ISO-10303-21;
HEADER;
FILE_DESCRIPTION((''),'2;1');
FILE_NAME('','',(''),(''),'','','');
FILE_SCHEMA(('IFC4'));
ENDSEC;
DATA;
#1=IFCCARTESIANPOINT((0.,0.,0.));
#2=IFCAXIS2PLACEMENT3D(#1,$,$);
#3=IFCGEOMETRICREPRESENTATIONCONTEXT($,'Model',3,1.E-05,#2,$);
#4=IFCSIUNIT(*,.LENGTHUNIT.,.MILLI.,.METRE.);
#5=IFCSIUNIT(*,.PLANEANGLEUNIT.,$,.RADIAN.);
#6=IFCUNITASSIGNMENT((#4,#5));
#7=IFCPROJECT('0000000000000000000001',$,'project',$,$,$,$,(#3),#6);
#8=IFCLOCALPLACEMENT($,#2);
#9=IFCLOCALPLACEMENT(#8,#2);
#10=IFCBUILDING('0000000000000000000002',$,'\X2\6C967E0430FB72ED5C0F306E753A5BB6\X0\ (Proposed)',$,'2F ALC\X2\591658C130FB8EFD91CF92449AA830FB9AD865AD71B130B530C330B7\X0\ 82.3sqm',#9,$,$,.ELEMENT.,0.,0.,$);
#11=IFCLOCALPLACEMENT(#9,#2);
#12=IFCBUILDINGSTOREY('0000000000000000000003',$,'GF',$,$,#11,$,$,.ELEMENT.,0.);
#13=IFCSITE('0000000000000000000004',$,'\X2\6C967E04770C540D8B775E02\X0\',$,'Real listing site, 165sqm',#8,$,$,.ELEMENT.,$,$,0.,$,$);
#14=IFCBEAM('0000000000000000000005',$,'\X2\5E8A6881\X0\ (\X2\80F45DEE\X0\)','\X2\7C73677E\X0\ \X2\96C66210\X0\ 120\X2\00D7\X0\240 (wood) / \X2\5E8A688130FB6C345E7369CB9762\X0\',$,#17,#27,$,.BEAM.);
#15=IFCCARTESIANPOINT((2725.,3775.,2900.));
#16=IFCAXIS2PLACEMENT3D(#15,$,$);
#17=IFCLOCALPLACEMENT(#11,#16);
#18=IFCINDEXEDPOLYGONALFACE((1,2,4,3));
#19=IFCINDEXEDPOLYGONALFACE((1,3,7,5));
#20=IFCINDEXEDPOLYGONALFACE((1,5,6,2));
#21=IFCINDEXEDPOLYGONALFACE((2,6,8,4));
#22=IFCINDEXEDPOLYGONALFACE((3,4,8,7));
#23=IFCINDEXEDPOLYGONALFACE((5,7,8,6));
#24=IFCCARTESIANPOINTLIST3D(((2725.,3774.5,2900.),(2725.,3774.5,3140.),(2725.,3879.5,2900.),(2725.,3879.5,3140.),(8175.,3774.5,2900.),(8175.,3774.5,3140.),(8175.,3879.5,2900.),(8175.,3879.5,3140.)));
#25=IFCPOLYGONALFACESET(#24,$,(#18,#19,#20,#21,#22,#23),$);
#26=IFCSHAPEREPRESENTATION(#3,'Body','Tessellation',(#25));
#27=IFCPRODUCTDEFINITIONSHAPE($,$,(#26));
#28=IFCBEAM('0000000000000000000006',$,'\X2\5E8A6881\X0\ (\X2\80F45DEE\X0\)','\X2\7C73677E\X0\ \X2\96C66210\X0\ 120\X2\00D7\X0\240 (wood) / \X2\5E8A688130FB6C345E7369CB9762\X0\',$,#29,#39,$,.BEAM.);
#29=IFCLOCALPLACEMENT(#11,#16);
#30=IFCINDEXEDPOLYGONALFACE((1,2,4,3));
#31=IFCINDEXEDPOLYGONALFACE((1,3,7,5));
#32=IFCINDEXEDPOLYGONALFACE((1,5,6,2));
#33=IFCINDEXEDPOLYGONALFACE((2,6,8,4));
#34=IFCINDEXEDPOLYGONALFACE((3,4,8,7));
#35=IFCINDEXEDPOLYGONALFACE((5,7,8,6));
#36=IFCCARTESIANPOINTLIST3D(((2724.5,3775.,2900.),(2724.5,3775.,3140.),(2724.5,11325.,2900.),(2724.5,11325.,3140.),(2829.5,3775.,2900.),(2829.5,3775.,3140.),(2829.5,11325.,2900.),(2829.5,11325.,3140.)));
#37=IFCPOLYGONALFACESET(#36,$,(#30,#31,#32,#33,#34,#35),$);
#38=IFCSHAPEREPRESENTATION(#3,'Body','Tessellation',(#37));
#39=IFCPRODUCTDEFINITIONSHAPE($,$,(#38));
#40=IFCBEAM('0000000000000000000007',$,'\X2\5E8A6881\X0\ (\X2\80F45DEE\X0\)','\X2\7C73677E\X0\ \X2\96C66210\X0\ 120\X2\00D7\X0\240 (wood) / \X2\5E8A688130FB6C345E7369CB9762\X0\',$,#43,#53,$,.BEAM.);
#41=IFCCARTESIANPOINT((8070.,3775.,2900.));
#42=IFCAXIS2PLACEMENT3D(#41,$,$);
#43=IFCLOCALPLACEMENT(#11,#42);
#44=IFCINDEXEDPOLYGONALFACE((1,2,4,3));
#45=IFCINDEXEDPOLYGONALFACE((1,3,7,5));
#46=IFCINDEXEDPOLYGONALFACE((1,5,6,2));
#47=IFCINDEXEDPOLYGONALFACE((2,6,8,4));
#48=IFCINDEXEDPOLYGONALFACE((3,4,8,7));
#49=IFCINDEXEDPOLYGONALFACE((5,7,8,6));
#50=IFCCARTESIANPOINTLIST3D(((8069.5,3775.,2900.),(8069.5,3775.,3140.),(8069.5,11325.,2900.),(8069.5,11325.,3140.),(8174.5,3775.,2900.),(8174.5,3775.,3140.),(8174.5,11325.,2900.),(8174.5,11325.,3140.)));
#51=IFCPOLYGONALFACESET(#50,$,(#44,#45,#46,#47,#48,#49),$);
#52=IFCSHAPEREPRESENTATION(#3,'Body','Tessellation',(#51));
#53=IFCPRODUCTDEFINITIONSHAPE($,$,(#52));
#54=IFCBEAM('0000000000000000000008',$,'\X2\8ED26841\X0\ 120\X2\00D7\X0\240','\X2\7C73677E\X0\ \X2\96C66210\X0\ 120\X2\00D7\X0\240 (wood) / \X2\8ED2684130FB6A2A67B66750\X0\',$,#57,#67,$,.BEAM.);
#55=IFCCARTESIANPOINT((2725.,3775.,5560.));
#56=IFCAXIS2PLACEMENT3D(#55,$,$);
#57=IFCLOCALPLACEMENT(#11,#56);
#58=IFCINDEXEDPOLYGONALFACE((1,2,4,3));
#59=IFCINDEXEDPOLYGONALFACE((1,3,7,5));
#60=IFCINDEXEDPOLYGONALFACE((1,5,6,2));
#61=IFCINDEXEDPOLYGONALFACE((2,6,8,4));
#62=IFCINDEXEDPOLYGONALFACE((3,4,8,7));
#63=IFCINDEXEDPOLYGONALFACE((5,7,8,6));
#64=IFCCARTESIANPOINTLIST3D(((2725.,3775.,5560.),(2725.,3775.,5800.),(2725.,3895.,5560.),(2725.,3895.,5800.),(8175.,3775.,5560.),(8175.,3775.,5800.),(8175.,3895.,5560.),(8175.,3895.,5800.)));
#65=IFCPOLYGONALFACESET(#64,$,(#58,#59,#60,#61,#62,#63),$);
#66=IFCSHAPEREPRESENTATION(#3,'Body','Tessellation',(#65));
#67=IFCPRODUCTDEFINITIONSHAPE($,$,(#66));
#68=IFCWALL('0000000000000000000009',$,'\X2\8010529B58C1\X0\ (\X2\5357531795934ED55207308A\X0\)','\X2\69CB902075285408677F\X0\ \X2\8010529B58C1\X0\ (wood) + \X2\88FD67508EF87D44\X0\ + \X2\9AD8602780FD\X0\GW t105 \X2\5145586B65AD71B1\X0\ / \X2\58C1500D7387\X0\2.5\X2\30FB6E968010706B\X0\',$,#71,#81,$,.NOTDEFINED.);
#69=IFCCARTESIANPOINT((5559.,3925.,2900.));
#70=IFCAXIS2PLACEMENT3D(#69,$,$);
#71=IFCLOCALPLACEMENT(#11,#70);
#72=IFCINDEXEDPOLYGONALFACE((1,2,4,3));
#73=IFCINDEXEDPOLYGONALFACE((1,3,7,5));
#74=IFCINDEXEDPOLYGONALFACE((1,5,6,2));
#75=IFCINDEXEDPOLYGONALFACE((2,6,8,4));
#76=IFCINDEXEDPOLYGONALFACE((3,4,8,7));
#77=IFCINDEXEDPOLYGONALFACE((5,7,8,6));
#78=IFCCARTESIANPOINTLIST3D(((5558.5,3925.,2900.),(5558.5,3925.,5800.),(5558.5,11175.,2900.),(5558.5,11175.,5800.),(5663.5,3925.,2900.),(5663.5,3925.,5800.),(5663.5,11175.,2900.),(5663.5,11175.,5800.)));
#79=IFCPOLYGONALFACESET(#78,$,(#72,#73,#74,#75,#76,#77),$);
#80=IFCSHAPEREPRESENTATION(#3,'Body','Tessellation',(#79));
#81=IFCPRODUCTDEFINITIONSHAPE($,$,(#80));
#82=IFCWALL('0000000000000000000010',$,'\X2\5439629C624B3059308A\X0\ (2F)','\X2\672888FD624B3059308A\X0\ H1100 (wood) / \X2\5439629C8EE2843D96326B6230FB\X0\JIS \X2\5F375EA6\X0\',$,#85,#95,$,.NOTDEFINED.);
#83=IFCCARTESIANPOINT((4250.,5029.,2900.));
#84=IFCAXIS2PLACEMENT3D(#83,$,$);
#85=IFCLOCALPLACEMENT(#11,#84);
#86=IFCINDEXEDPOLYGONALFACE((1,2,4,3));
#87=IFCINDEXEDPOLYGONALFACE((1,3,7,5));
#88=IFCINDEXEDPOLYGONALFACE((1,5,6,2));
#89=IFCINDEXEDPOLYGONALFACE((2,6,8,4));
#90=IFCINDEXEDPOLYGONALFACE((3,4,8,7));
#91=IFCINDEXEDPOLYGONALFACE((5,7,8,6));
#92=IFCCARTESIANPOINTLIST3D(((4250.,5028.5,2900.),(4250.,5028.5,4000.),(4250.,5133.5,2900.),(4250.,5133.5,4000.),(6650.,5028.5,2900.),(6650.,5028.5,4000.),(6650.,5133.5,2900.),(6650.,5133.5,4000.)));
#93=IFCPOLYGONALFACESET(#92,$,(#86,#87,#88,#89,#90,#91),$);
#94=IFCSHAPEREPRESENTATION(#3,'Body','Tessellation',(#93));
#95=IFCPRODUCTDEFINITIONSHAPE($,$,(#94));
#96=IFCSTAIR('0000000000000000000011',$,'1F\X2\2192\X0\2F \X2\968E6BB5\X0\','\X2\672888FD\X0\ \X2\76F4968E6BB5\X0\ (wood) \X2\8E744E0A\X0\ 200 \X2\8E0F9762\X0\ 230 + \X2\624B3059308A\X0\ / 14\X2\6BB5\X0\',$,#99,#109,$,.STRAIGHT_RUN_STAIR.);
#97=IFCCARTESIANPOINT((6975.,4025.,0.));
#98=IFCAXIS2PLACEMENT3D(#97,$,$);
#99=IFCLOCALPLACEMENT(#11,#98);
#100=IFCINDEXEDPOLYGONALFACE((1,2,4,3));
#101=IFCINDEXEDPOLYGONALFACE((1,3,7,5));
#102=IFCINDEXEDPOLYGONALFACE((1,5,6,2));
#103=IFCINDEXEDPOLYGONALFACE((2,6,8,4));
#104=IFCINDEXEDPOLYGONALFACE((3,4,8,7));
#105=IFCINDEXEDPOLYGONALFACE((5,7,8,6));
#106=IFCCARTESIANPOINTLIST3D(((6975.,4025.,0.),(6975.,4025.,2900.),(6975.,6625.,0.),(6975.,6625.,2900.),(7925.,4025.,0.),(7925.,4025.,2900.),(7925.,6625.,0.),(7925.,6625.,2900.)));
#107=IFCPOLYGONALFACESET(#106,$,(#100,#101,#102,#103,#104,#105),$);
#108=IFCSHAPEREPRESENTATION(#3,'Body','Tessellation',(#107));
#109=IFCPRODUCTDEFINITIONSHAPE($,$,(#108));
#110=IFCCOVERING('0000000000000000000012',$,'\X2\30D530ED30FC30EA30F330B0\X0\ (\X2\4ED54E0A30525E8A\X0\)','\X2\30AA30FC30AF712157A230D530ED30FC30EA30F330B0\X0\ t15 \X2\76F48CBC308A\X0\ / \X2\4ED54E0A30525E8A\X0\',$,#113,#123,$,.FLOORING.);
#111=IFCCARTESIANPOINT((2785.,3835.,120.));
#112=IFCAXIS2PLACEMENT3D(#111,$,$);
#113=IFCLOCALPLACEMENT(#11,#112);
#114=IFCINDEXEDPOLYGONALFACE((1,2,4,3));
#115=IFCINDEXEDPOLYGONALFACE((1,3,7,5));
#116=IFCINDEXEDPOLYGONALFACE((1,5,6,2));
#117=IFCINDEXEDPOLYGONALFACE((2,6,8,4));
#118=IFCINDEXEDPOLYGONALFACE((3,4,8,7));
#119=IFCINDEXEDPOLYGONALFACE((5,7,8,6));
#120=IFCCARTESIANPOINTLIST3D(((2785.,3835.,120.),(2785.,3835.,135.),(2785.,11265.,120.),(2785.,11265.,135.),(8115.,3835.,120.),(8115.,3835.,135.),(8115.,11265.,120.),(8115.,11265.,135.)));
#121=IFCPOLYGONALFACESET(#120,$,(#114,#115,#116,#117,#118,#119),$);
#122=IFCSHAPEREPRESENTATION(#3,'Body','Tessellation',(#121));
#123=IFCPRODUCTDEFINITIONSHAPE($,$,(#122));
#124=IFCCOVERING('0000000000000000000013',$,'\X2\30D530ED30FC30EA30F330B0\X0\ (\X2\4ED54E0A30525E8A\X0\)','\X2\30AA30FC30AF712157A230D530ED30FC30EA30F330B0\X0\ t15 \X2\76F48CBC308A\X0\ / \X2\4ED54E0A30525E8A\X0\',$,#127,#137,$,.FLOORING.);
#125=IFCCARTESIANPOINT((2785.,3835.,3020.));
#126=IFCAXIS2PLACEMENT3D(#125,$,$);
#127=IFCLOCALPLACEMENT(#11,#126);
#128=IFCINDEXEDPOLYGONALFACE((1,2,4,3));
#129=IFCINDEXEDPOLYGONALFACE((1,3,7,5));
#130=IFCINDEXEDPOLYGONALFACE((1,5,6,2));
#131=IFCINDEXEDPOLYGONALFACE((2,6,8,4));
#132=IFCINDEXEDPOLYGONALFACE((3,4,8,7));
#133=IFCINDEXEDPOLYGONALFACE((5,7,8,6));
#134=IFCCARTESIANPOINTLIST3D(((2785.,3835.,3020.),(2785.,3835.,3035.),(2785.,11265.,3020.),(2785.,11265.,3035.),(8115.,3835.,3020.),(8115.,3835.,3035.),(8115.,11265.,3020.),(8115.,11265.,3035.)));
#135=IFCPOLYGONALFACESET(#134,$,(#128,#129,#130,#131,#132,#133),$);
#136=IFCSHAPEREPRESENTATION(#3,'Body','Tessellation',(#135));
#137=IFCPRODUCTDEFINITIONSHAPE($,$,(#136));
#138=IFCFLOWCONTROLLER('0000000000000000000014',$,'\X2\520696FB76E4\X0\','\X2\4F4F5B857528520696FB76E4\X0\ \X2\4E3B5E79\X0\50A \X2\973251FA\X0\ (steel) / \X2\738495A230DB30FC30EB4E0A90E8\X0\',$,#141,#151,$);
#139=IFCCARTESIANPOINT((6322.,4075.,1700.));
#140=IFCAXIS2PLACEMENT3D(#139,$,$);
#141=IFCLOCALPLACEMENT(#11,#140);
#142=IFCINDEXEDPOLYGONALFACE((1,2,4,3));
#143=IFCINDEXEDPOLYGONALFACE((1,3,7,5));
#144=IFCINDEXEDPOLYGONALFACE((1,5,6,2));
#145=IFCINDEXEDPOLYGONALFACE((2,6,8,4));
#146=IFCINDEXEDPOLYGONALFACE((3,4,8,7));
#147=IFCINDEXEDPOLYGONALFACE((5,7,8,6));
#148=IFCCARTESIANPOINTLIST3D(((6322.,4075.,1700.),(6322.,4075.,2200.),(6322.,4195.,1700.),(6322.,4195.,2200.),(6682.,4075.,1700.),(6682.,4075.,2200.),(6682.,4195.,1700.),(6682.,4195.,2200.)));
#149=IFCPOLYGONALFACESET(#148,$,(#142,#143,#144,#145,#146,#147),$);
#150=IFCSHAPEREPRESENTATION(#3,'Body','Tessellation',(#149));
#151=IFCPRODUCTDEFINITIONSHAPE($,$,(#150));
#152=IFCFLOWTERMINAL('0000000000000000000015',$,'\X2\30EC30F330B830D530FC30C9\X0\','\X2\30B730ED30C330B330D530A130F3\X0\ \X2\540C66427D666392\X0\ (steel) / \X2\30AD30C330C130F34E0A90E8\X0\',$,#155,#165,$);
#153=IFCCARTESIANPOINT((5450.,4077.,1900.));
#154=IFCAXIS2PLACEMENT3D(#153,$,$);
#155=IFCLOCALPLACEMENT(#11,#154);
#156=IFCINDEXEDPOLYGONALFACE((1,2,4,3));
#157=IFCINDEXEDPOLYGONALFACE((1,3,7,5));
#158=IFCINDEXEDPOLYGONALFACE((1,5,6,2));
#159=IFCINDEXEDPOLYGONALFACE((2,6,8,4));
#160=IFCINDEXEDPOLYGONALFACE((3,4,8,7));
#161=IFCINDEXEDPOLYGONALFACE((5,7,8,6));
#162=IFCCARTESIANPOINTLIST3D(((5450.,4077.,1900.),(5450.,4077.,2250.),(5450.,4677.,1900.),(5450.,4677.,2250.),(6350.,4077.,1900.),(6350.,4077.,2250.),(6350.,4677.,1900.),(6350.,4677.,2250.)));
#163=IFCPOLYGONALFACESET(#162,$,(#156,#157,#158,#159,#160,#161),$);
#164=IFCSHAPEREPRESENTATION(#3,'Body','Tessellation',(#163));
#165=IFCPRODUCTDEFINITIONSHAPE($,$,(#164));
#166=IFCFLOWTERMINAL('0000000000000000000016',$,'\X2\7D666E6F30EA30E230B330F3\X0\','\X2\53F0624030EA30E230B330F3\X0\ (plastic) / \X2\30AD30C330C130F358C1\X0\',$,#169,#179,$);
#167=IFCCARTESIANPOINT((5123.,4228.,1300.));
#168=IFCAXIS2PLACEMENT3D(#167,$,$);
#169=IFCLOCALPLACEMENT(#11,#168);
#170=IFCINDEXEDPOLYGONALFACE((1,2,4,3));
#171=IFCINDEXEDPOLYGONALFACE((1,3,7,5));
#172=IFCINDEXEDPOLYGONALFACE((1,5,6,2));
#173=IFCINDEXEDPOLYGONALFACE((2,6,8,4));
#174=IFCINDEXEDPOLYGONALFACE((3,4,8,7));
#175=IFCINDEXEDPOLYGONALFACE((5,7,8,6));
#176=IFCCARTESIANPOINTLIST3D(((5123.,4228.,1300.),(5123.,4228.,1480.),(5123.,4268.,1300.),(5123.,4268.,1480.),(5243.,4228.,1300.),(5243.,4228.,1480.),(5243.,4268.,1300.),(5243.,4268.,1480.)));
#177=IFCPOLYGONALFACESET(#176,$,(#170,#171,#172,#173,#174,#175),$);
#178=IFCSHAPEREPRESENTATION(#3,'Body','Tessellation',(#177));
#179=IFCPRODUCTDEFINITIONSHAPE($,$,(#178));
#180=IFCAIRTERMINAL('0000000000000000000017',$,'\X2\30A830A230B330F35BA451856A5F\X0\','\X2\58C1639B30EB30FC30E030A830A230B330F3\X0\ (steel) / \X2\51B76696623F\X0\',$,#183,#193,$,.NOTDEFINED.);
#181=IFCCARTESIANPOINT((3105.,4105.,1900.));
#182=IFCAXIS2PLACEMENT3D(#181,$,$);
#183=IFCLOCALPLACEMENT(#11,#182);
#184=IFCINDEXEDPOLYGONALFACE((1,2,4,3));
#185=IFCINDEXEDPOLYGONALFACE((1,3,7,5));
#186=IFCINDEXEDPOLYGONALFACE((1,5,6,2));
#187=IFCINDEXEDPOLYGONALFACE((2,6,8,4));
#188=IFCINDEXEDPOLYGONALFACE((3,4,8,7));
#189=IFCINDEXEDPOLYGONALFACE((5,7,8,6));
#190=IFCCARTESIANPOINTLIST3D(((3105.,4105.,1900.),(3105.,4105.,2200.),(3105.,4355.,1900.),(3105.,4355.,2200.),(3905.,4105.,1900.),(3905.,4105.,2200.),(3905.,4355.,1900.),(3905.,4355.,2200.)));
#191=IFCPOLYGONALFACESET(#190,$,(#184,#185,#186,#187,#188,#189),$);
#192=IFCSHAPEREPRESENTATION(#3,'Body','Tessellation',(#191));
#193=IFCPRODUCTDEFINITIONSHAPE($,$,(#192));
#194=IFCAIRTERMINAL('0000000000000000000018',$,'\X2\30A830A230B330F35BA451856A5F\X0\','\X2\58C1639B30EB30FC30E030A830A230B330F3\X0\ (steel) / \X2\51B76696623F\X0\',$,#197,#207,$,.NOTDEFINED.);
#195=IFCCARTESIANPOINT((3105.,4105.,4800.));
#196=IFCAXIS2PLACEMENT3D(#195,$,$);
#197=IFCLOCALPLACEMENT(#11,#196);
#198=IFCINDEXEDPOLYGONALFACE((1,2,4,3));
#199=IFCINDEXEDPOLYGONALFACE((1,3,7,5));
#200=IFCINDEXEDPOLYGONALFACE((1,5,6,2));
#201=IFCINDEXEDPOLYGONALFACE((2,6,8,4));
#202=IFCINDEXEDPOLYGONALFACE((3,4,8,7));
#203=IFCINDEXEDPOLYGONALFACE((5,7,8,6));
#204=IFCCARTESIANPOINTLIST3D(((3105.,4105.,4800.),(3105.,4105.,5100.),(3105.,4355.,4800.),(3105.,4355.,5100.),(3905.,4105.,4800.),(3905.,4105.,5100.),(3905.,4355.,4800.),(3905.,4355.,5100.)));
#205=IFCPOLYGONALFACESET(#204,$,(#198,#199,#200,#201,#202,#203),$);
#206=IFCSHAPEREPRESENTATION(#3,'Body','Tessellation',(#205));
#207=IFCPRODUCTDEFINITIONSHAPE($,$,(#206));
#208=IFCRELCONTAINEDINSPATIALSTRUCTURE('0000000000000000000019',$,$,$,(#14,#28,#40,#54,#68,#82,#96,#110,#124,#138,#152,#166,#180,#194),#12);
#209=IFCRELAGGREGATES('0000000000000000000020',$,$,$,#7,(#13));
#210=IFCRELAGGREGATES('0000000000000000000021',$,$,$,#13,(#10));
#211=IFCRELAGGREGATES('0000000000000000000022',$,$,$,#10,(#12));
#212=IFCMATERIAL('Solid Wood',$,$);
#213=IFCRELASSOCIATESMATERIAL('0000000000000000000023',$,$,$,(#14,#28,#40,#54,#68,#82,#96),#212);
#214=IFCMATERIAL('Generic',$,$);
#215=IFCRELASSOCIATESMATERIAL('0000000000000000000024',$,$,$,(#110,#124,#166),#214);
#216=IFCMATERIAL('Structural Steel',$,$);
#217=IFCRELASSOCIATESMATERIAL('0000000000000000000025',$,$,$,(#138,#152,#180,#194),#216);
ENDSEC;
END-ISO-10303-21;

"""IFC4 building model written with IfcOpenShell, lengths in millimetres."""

from ifc_helpers import new_model, si_unit, frame, frame_2d, origin, place, context, project, spatial, rectangle, extrude, material, element, save


model = new_model("IFC4")

# Units and contexts
model_context = context("Model", 3, precision=1e-05, world=origin())
ifc_project = project(units=[si_unit("LENGTHUNIT", "METRE", prefix="MILLI"), si_unit("PLANEANGLEUNIT", "RADIAN")], contexts=[model_context])

# Site, building, storey
site_placement = place(None, origin())
site = spatial("IfcSite", under=ifc_project, at=site_placement, Name="沖縄県名護市", ObjectType="Real listing site, 165sqm", CompositionType="ELEMENT", RefElevation=0.0)
building_placement = place(site_placement, origin())
building = spatial("IfcBuilding", under=site, at=building_placement, Name="沖縄・狭小の町家 (Proposed)", ObjectType="2F ALC外壁・軽量鉄骨・高断熱サッシ 82.3sqm", CompositionType="ELEMENT", ElevationOfRefHeight=0.0, ElevationOfTerrain=0.0)
storey_placement = place(building_placement, origin())
storey = spatial("IfcBuildingStorey", under=building, at=storey_placement, Name="GF", CompositionType="ELEMENT", Elevation=0.0)

# Shared definitions
ifc_material_1 = material(Name="Solid Wood")

# Beams
beam_1_placement = place(storey_placement, frame((2725.0, 3775.0, 2900.0)))
element("IfcBeam", 1, at=beam_1_placement, inside=storey, material=ifc_material_1, Name="床梁 (胴差)", Description="米松 集成 120×240 (wood) / 床梁・水平構面", PredefinedType="BEAM", context=model_context, shape_type="SweptSolid", body=[
    extrude(rectangle(XDim=5450.0, YDim=105.0, at=frame_2d((2725.0, 52.0))), frame((2725.0, 3775.0, 2900.0)), (0.0, 0.0, 1.0), 240.0),
])
beam_2_placement = place(storey_placement, frame((2725.0, 3775.0, 2900.0)))
element("IfcBeam", 2, at=beam_2_placement, inside=storey, material=ifc_material_1, Name="床梁 (胴差)", Description="米松 集成 120×240 (wood) / 床梁・水平構面", PredefinedType="BEAM", context=model_context, shape_type="SweptSolid", body=[
    extrude(rectangle(XDim=105.0, YDim=7550.0, at=frame_2d((52.0, 3775.0))), frame((2725.0, 3775.0, 2900.0)), (0.0, 0.0, 1.0), 240.0),
])
beam_3_placement = place(storey_placement, frame((8070.0, 3775.0, 2900.0)))
element("IfcBeam", 3, at=beam_3_placement, inside=storey, material=ifc_material_1, Name="床梁 (胴差)", Description="米松 集成 120×240 (wood) / 床梁・水平構面", PredefinedType="BEAM", context=model_context, shape_type="SweptSolid", body=[
    extrude(rectangle(XDim=105.0, YDim=7550.0, at=frame_2d((52.0, 3775.0))), frame((8070.0, 3775.0, 2900.0)), (0.0, 0.0, 1.0), 240.0),
])
beam_4_placement = place(storey_placement, frame((2725.0, 3775.0, 5560.0)))
element("IfcBeam", 4, at=beam_4_placement, inside=storey, material=ifc_material_1, Name="軒桁 120×240", Description="米松 集成 120×240 (wood) / 軒桁・横架材", PredefinedType="BEAM", context=model_context, shape_type="SweptSolid", body=[
    extrude(rectangle(XDim=5450.0, YDim=120.0, at=frame_2d((2725.0, 60.0))), frame((2725.0, 3775.0, 5560.0)), (0.0, 0.0, 1.0), 240.0),
])

# Walls
wall_1_placement = place(storey_placement, frame((5559.0, 3925.0, 2900.0)))
element("IfcWall", 5, at=wall_1_placement, inside=storey, material=ifc_material_1, Name="耐力壁 (南北間仕切り)", Description="構造用合板 耐力壁 (wood) + 製材軸組 + 高性能GW t105 充填断熱 / 壁倍率2.5・準耐火", PredefinedType="NOTDEFINED", context=model_context, shape_type="SweptSolid", body=[
    extrude(rectangle(XDim=105.0, YDim=7250.0, at=frame_2d((52.0, 3625.0))), frame((5559.0, 3925.0, 2900.0)), (0.0, 0.0, 1.0), 2900.0),
])
wall_2_placement = place(storey_placement, frame((4250.0, 5029.0, 2900.0)))
element("IfcWall", 6, at=wall_2_placement, inside=storey, material=ifc_material_1, Name="吹抜手すり (2F)", Description="木製手すり H1100 (wood) / 吹抜転落防止・JIS 強度", PredefinedType="NOTDEFINED", context=model_context, shape_type="SweptSolid", body=[
    extrude(rectangle(XDim=2400.0, YDim=105.0, at=frame_2d((1200.0, 52.0))), frame((4250.0, 5029.0, 2900.0)), (0.0, 0.0, 1.0), 1100.0),
])

# Stair
stair_placement = place(storey_placement, frame((6975.0, 4025.0, 0.0)))
element("IfcStair", 7, at=stair_placement, inside=storey, material=ifc_material_1, Name="1F→2F 階段", Description="木製 直階段 (wood) 蹴上 200 踏面 230 + 手すり / 14段", PredefinedType="STRAIGHT_RUN_STAIR", context=model_context, shape_type="SweptSolid", body=[
    extrude(rectangle(XDim=950.0, YDim=2600.0, at=frame_2d((475.0, 1300.0))), frame((6975.0, 4025.0, 0.0)), (0.0, 0.0, 1.0), 2900.0),
])

# Coverings
ifc_material_2 = material(Name="Generic")
covering_1_placement = place(storey_placement, frame((2785.0, 3835.0, 120.0)))
element("IfcCovering", 8, at=covering_1_placement, inside=storey, material=ifc_material_2, Name="フローリング (仕上げ床)", Description="オーク無垢フローリング t15 直貼り / 仕上げ床", PredefinedType="FLOORING", context=model_context, shape_type="SweptSolid", body=[
    extrude(rectangle(XDim=5330.0, YDim=7430.0, at=frame_2d((2665.0, 3715.0))), frame((2785.0, 3835.0, 120.0)), (0.0, 0.0, 1.0), 15.0),
])
covering_2_placement = place(storey_placement, frame((2785.0, 3835.0, 3020.0)))
element("IfcCovering", 9, at=covering_2_placement, inside=storey, material=ifc_material_2, Name="フローリング (仕上げ床)", Description="オーク無垢フローリング t15 直貼り / 仕上げ床", PredefinedType="FLOORING", context=model_context, shape_type="SweptSolid", body=[
    extrude(rectangle(XDim=5330.0, YDim=7430.0, at=frame_2d((2665.0, 3715.0))), frame((2785.0, 3835.0, 3020.0)), (0.0, 0.0, 1.0), 15.0),
])

# Flow controller
ifc_material_3 = material(Name="Structural Steel")
flow_controller_placement = place(storey_placement, frame((6322.0, 4075.0, 1700.0)))
element("IfcFlowController", 10, at=flow_controller_placement, inside=storey, material=ifc_material_3, Name="分電盤", Description="住宅用分電盤 主幹50A 露出 (steel) / 玄関ホール上部", context=model_context, shape_type="SweptSolid", body=[
    extrude(rectangle(XDim=360.0, YDim=120.0, at=frame_2d((180.0, 60.0))), frame((6322.0, 4075.0, 1700.0)), (0.0, 0.0, 1.0), 500.0),
])

# Flow terminals
flow_terminal_1_placement = place(storey_placement, frame((5450.0, 4077.0, 1900.0)))
element("IfcFlowTerminal", 11, at=flow_terminal_1_placement, inside=storey, material=ifc_material_3, Name="レンジフード", Description="シロッコファン 同時給排 (steel) / キッチン上部", context=model_context, shape_type="SweptSolid", body=[
    extrude(rectangle(XDim=900.0, YDim=600.0, at=frame_2d((450.0, 300.0))), frame((5450.0, 4077.0, 1900.0)), (0.0, 0.0, 1.0), 350.0),
])
flow_terminal_2_placement = place(storey_placement, frame((5123.0, 4228.0, 1300.0)))
element("IfcFlowTerminal", 12, at=flow_terminal_2_placement, inside=storey, material=ifc_material_2, Name="給湯リモコン", Description="台所リモコン (plastic) / キッチン壁", context=model_context, shape_type="SweptSolid", body=[
    extrude(rectangle(XDim=120.0, YDim=40.0, at=frame_2d((60.0, 20.0))), frame((5123.0, 4228.0, 1300.0)), (0.0, 0.0, 1.0), 180.0),
])

# Air terminals
air_terminal_1_placement = place(storey_placement, frame((3105.0, 4105.0, 1900.0)))
element("IfcAirTerminal", 13, at=air_terminal_1_placement, inside=storey, material=ifc_material_3, Name="エアコン室内機", Description="壁掛ルームエアコン (steel) / 冷暖房", PredefinedType="NOTDEFINED", context=model_context, shape_type="SweptSolid", body=[
    extrude(rectangle(XDim=800.0, YDim=250.0, at=frame_2d((400.0, 125.0))), frame((3105.0, 4105.0, 1900.0)), (0.0, 0.0, 1.0), 300.0),
])
air_terminal_2_placement = place(storey_placement, frame((3105.0, 4105.0, 4800.0)))
element("IfcAirTerminal", 14, at=air_terminal_2_placement, inside=storey, material=ifc_material_3, Name="エアコン室内機", Description="壁掛ルームエアコン (steel) / 冷暖房", PredefinedType="NOTDEFINED", context=model_context, shape_type="SweptSolid", body=[
    extrude(rectangle(XDim=800.0, YDim=250.0, at=frame_2d((400.0, 125.0))), frame((3105.0, 4105.0, 4800.0)), (0.0, 0.0, 1.0), 300.0),
])

save(model, "model.ifc")
